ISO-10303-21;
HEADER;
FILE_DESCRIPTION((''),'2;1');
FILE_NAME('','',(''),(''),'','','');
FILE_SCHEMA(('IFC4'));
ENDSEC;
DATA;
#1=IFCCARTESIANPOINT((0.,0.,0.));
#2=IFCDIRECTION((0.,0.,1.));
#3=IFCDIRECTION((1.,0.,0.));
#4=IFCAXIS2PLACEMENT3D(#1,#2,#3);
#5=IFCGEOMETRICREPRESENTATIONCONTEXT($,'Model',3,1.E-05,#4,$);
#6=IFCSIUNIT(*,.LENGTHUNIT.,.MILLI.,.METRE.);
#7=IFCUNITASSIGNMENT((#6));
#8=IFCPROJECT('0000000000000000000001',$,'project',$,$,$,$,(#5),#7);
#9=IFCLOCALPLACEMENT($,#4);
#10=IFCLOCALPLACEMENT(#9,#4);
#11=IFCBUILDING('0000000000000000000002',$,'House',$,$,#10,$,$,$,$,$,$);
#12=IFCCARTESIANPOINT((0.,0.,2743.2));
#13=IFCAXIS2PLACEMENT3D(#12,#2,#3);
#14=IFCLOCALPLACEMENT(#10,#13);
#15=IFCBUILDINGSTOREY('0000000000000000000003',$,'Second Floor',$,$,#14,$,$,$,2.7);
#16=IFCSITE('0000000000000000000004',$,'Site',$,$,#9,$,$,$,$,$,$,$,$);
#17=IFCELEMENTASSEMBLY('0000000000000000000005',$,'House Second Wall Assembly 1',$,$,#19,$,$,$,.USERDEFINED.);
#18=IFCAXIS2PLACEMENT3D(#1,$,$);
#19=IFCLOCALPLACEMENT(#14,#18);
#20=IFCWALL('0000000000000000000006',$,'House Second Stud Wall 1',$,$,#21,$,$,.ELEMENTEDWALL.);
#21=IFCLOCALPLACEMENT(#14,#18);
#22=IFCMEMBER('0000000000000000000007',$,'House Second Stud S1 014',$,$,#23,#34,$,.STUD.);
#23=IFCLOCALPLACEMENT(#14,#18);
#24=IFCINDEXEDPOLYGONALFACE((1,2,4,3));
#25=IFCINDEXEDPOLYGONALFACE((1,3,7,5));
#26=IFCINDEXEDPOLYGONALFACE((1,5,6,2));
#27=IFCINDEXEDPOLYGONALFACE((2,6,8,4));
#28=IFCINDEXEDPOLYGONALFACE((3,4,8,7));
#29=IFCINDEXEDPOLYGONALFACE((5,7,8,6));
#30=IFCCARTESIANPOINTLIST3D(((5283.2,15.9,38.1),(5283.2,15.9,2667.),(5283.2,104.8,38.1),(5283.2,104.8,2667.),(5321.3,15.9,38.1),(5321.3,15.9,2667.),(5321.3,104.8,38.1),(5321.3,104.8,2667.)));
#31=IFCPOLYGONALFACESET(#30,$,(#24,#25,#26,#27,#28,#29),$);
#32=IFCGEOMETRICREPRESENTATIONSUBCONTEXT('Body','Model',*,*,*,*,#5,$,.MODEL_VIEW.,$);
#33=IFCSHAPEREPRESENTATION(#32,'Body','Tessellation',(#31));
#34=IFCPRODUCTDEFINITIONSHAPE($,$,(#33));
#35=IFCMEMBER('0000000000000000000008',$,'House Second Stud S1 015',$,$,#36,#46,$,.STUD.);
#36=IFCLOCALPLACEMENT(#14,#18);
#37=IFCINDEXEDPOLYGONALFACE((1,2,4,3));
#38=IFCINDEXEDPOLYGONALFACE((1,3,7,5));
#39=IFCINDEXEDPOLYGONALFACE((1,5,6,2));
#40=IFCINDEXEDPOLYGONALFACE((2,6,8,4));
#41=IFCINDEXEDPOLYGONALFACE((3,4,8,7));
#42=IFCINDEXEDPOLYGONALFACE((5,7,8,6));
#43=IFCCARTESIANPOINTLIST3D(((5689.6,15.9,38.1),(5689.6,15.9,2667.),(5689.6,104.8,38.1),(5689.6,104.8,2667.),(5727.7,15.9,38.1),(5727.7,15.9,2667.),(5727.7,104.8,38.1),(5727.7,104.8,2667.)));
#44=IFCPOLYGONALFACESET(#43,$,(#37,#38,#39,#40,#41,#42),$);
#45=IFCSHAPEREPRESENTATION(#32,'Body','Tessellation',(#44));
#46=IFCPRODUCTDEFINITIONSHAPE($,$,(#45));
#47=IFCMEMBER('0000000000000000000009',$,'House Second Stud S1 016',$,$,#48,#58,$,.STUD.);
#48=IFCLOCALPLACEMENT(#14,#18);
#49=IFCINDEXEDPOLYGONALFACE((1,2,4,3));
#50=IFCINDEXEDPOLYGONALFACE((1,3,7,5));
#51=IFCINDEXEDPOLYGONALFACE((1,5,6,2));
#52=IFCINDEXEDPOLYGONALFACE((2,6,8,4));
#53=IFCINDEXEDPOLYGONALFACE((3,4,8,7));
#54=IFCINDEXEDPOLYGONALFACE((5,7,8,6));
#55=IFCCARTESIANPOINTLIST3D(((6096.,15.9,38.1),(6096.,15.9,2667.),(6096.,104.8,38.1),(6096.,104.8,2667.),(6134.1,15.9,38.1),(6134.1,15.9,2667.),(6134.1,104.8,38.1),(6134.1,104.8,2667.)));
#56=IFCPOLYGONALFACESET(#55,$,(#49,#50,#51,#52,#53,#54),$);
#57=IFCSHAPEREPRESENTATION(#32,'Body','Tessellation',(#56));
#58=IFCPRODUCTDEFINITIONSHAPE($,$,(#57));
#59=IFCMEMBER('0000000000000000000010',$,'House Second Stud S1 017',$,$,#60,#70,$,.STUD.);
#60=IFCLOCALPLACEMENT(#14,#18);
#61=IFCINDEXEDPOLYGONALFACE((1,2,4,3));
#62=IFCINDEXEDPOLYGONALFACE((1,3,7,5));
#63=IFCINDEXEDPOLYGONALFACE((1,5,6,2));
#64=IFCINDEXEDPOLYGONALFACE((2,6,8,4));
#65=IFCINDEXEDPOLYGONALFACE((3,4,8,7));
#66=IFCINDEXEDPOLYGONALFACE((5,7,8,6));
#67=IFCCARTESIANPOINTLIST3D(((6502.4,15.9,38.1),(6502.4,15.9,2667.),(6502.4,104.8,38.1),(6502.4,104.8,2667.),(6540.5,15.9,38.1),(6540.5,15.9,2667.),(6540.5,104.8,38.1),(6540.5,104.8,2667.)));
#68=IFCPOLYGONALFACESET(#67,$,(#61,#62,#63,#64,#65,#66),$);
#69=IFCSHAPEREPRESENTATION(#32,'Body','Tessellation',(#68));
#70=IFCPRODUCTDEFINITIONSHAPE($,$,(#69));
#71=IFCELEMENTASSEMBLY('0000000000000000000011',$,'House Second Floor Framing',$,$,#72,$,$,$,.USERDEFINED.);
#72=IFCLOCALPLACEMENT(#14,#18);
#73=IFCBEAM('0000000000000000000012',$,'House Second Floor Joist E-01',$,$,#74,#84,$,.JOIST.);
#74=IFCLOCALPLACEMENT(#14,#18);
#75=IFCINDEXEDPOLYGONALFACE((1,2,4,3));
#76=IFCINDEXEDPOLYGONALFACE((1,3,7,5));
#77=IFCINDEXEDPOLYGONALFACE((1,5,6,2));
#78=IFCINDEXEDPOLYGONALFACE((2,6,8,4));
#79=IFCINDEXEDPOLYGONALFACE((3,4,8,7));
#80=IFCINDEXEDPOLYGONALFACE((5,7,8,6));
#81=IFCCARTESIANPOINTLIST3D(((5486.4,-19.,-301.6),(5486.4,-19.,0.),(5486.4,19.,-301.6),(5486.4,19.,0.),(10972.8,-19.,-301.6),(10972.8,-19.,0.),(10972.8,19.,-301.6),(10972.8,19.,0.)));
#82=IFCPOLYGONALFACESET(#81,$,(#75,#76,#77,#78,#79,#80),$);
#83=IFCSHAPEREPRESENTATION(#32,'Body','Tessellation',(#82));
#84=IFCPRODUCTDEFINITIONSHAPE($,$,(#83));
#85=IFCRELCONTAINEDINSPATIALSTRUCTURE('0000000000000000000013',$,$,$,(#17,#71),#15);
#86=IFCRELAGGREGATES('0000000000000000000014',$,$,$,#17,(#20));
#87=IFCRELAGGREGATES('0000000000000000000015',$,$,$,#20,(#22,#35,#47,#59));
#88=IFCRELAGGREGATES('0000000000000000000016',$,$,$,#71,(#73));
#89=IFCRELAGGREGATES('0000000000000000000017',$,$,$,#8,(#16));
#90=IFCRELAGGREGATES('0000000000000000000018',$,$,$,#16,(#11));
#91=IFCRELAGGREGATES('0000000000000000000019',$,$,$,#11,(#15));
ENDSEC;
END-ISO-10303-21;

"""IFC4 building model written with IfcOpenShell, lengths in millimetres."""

from ifc_helpers import new_model, si_unit, frame, origin_with_axes, origin_2d, place, context, subcontext, project, spatial, rectangle, extrude, element, aggregate, save


model = new_model("IFC4")

# Units and contexts
model_context = context("Model", 3, precision=1e-05, world=origin_with_axes())
body_context = subcontext(model_context, "Body", "Model", "MODEL_VIEW")
ifc_project = project(units=[si_unit("LENGTHUNIT", "METRE", prefix="MILLI")], contexts=[model_context])

# Site, building, storey
site_placement = place(None, origin_with_axes())
site = spatial("IfcSite", under=ifc_project, at=site_placement, Name="Site")
building_placement = place(site_placement, origin_with_axes())
building = spatial("IfcBuilding", under=site, at=building_placement, Name="House")
storey_placement = place(building_placement, frame((0.0, 0.0, 2743.2), z_axis=(0.0, 0.0, 1.0), x_axis=(1.0, 0.0, 0.0)))
storey = spatial("IfcBuildingStorey", under=building, at=storey_placement, Name="Second Floor", Elevation=2.7)

# Element assembly, wall, members
assembly_1_placement = place(storey_placement, frame((0.0, 0.0, -2743.2), z_axis=(0.0, 0.0, 1.0), x_axis=(1.0, 0.0, 0.0)))
assembly_1 = element("IfcElementAssembly", 1, at=assembly_1_placement, inside=storey, Name="House Second Wall Assembly 1", PredefinedType="USERDEFINED")
wall_1_placement = place(assembly_1_placement, frame((0.0, 0.0, 2743.2), z_axis=(0.0, 0.0, 1.0), x_axis=(1.0, 0.0, 0.0)))
wall_1 = element("IfcWall", 2, at=wall_1_placement, Name="House Second Stud Wall 1", PredefinedType="ELEMENTEDWALL")
aggregate(assembly_1, [wall_1])
member_1_placement = place(wall_1_placement, frame((5302.2, 60.3, 38.1), z_axis=(0.0, 0.0, 1.0), x_axis=(1.0, 0.0, 0.0)))
member_1 = element("IfcMember", 3, at=member_1_placement, Name="House Second Stud S1 014", PredefinedType="STUD", context=body_context, shape_type="SweptSolid", body=[
    extrude(rectangle(XDim=38.1, YDim=88.9, at=origin_2d()), origin_with_axes(), (0.0, 0.0, 1.0), 2628.9),
])
member_2_placement = place(wall_1_placement, frame((5708.6, 60.3, 38.1), z_axis=(0.0, 0.0, 1.0), x_axis=(1.0, 0.0, 0.0)))
member_2 = element("IfcMember", 4, at=member_2_placement, Name="House Second Stud S1 015", PredefinedType="STUD", context=body_context, shape_type="SweptSolid", body=[
    extrude(rectangle(XDim=38.1, YDim=88.9, at=origin_2d()), origin_with_axes(), (0.0, 0.0, 1.0), 2628.9),
])
member_3_placement = place(wall_1_placement, frame((6115.1, 60.3, 38.1), z_axis=(0.0, 0.0, 1.0), x_axis=(1.0, 0.0, 0.0)))
member_3 = element("IfcMember", 5, at=member_3_placement, Name="House Second Stud S1 016", PredefinedType="STUD", context=body_context, shape_type="SweptSolid", body=[
    extrude(rectangle(XDim=38.1, YDim=88.9, at=origin_2d()), origin_with_axes(), (0.0, 0.0, 1.0), 2628.9),
])
member_4_placement = place(wall_1_placement, frame((6521.4, 60.3, 38.1), z_axis=(0.0, 0.0, 1.0), x_axis=(1.0, 0.0, 0.0)))
member_4 = element("IfcMember", 6, at=member_4_placement, Name="House Second Stud S1 017", PredefinedType="STUD", context=body_context, shape_type="SweptSolid", body=[
    extrude(rectangle(XDim=38.1, YDim=88.9, at=origin_2d()), origin_with_axes(), (0.0, 0.0, 1.0), 2628.9),
])
aggregate(wall_1, [member_1, member_2, member_3, member_4])

# Element assembly, beam
assembly_2_placement = place(storey_placement, frame((0.0, 0.0, -2743.2), z_axis=(0.0, 0.0, 1.0), x_axis=(1.0, 0.0, 0.0)))
assembly_2 = element("IfcElementAssembly", 7, at=assembly_2_placement, inside=storey, Name="House Second Floor Framing", PredefinedType="USERDEFINED")
beam_placement = place(assembly_2_placement, frame((5486.4, 0.0, 2592.4), z_axis=(1.0, 0.0, 0.0), x_axis=(0.0, 1.0, 0.0)))
beam = element("IfcBeam", 8, at=beam_placement, Name="House Second Floor Joist E-01", PredefinedType="JOIST", context=body_context, shape_type="SweptSolid", body=[
    extrude(rectangle(XDim=38.1, YDim=301.6, at=origin_2d()), origin_with_axes(), (0.0, 0.0, 1.0), 5486.4),
])
aggregate(assembly_2, [beam])

save(model, "model.ifc")
